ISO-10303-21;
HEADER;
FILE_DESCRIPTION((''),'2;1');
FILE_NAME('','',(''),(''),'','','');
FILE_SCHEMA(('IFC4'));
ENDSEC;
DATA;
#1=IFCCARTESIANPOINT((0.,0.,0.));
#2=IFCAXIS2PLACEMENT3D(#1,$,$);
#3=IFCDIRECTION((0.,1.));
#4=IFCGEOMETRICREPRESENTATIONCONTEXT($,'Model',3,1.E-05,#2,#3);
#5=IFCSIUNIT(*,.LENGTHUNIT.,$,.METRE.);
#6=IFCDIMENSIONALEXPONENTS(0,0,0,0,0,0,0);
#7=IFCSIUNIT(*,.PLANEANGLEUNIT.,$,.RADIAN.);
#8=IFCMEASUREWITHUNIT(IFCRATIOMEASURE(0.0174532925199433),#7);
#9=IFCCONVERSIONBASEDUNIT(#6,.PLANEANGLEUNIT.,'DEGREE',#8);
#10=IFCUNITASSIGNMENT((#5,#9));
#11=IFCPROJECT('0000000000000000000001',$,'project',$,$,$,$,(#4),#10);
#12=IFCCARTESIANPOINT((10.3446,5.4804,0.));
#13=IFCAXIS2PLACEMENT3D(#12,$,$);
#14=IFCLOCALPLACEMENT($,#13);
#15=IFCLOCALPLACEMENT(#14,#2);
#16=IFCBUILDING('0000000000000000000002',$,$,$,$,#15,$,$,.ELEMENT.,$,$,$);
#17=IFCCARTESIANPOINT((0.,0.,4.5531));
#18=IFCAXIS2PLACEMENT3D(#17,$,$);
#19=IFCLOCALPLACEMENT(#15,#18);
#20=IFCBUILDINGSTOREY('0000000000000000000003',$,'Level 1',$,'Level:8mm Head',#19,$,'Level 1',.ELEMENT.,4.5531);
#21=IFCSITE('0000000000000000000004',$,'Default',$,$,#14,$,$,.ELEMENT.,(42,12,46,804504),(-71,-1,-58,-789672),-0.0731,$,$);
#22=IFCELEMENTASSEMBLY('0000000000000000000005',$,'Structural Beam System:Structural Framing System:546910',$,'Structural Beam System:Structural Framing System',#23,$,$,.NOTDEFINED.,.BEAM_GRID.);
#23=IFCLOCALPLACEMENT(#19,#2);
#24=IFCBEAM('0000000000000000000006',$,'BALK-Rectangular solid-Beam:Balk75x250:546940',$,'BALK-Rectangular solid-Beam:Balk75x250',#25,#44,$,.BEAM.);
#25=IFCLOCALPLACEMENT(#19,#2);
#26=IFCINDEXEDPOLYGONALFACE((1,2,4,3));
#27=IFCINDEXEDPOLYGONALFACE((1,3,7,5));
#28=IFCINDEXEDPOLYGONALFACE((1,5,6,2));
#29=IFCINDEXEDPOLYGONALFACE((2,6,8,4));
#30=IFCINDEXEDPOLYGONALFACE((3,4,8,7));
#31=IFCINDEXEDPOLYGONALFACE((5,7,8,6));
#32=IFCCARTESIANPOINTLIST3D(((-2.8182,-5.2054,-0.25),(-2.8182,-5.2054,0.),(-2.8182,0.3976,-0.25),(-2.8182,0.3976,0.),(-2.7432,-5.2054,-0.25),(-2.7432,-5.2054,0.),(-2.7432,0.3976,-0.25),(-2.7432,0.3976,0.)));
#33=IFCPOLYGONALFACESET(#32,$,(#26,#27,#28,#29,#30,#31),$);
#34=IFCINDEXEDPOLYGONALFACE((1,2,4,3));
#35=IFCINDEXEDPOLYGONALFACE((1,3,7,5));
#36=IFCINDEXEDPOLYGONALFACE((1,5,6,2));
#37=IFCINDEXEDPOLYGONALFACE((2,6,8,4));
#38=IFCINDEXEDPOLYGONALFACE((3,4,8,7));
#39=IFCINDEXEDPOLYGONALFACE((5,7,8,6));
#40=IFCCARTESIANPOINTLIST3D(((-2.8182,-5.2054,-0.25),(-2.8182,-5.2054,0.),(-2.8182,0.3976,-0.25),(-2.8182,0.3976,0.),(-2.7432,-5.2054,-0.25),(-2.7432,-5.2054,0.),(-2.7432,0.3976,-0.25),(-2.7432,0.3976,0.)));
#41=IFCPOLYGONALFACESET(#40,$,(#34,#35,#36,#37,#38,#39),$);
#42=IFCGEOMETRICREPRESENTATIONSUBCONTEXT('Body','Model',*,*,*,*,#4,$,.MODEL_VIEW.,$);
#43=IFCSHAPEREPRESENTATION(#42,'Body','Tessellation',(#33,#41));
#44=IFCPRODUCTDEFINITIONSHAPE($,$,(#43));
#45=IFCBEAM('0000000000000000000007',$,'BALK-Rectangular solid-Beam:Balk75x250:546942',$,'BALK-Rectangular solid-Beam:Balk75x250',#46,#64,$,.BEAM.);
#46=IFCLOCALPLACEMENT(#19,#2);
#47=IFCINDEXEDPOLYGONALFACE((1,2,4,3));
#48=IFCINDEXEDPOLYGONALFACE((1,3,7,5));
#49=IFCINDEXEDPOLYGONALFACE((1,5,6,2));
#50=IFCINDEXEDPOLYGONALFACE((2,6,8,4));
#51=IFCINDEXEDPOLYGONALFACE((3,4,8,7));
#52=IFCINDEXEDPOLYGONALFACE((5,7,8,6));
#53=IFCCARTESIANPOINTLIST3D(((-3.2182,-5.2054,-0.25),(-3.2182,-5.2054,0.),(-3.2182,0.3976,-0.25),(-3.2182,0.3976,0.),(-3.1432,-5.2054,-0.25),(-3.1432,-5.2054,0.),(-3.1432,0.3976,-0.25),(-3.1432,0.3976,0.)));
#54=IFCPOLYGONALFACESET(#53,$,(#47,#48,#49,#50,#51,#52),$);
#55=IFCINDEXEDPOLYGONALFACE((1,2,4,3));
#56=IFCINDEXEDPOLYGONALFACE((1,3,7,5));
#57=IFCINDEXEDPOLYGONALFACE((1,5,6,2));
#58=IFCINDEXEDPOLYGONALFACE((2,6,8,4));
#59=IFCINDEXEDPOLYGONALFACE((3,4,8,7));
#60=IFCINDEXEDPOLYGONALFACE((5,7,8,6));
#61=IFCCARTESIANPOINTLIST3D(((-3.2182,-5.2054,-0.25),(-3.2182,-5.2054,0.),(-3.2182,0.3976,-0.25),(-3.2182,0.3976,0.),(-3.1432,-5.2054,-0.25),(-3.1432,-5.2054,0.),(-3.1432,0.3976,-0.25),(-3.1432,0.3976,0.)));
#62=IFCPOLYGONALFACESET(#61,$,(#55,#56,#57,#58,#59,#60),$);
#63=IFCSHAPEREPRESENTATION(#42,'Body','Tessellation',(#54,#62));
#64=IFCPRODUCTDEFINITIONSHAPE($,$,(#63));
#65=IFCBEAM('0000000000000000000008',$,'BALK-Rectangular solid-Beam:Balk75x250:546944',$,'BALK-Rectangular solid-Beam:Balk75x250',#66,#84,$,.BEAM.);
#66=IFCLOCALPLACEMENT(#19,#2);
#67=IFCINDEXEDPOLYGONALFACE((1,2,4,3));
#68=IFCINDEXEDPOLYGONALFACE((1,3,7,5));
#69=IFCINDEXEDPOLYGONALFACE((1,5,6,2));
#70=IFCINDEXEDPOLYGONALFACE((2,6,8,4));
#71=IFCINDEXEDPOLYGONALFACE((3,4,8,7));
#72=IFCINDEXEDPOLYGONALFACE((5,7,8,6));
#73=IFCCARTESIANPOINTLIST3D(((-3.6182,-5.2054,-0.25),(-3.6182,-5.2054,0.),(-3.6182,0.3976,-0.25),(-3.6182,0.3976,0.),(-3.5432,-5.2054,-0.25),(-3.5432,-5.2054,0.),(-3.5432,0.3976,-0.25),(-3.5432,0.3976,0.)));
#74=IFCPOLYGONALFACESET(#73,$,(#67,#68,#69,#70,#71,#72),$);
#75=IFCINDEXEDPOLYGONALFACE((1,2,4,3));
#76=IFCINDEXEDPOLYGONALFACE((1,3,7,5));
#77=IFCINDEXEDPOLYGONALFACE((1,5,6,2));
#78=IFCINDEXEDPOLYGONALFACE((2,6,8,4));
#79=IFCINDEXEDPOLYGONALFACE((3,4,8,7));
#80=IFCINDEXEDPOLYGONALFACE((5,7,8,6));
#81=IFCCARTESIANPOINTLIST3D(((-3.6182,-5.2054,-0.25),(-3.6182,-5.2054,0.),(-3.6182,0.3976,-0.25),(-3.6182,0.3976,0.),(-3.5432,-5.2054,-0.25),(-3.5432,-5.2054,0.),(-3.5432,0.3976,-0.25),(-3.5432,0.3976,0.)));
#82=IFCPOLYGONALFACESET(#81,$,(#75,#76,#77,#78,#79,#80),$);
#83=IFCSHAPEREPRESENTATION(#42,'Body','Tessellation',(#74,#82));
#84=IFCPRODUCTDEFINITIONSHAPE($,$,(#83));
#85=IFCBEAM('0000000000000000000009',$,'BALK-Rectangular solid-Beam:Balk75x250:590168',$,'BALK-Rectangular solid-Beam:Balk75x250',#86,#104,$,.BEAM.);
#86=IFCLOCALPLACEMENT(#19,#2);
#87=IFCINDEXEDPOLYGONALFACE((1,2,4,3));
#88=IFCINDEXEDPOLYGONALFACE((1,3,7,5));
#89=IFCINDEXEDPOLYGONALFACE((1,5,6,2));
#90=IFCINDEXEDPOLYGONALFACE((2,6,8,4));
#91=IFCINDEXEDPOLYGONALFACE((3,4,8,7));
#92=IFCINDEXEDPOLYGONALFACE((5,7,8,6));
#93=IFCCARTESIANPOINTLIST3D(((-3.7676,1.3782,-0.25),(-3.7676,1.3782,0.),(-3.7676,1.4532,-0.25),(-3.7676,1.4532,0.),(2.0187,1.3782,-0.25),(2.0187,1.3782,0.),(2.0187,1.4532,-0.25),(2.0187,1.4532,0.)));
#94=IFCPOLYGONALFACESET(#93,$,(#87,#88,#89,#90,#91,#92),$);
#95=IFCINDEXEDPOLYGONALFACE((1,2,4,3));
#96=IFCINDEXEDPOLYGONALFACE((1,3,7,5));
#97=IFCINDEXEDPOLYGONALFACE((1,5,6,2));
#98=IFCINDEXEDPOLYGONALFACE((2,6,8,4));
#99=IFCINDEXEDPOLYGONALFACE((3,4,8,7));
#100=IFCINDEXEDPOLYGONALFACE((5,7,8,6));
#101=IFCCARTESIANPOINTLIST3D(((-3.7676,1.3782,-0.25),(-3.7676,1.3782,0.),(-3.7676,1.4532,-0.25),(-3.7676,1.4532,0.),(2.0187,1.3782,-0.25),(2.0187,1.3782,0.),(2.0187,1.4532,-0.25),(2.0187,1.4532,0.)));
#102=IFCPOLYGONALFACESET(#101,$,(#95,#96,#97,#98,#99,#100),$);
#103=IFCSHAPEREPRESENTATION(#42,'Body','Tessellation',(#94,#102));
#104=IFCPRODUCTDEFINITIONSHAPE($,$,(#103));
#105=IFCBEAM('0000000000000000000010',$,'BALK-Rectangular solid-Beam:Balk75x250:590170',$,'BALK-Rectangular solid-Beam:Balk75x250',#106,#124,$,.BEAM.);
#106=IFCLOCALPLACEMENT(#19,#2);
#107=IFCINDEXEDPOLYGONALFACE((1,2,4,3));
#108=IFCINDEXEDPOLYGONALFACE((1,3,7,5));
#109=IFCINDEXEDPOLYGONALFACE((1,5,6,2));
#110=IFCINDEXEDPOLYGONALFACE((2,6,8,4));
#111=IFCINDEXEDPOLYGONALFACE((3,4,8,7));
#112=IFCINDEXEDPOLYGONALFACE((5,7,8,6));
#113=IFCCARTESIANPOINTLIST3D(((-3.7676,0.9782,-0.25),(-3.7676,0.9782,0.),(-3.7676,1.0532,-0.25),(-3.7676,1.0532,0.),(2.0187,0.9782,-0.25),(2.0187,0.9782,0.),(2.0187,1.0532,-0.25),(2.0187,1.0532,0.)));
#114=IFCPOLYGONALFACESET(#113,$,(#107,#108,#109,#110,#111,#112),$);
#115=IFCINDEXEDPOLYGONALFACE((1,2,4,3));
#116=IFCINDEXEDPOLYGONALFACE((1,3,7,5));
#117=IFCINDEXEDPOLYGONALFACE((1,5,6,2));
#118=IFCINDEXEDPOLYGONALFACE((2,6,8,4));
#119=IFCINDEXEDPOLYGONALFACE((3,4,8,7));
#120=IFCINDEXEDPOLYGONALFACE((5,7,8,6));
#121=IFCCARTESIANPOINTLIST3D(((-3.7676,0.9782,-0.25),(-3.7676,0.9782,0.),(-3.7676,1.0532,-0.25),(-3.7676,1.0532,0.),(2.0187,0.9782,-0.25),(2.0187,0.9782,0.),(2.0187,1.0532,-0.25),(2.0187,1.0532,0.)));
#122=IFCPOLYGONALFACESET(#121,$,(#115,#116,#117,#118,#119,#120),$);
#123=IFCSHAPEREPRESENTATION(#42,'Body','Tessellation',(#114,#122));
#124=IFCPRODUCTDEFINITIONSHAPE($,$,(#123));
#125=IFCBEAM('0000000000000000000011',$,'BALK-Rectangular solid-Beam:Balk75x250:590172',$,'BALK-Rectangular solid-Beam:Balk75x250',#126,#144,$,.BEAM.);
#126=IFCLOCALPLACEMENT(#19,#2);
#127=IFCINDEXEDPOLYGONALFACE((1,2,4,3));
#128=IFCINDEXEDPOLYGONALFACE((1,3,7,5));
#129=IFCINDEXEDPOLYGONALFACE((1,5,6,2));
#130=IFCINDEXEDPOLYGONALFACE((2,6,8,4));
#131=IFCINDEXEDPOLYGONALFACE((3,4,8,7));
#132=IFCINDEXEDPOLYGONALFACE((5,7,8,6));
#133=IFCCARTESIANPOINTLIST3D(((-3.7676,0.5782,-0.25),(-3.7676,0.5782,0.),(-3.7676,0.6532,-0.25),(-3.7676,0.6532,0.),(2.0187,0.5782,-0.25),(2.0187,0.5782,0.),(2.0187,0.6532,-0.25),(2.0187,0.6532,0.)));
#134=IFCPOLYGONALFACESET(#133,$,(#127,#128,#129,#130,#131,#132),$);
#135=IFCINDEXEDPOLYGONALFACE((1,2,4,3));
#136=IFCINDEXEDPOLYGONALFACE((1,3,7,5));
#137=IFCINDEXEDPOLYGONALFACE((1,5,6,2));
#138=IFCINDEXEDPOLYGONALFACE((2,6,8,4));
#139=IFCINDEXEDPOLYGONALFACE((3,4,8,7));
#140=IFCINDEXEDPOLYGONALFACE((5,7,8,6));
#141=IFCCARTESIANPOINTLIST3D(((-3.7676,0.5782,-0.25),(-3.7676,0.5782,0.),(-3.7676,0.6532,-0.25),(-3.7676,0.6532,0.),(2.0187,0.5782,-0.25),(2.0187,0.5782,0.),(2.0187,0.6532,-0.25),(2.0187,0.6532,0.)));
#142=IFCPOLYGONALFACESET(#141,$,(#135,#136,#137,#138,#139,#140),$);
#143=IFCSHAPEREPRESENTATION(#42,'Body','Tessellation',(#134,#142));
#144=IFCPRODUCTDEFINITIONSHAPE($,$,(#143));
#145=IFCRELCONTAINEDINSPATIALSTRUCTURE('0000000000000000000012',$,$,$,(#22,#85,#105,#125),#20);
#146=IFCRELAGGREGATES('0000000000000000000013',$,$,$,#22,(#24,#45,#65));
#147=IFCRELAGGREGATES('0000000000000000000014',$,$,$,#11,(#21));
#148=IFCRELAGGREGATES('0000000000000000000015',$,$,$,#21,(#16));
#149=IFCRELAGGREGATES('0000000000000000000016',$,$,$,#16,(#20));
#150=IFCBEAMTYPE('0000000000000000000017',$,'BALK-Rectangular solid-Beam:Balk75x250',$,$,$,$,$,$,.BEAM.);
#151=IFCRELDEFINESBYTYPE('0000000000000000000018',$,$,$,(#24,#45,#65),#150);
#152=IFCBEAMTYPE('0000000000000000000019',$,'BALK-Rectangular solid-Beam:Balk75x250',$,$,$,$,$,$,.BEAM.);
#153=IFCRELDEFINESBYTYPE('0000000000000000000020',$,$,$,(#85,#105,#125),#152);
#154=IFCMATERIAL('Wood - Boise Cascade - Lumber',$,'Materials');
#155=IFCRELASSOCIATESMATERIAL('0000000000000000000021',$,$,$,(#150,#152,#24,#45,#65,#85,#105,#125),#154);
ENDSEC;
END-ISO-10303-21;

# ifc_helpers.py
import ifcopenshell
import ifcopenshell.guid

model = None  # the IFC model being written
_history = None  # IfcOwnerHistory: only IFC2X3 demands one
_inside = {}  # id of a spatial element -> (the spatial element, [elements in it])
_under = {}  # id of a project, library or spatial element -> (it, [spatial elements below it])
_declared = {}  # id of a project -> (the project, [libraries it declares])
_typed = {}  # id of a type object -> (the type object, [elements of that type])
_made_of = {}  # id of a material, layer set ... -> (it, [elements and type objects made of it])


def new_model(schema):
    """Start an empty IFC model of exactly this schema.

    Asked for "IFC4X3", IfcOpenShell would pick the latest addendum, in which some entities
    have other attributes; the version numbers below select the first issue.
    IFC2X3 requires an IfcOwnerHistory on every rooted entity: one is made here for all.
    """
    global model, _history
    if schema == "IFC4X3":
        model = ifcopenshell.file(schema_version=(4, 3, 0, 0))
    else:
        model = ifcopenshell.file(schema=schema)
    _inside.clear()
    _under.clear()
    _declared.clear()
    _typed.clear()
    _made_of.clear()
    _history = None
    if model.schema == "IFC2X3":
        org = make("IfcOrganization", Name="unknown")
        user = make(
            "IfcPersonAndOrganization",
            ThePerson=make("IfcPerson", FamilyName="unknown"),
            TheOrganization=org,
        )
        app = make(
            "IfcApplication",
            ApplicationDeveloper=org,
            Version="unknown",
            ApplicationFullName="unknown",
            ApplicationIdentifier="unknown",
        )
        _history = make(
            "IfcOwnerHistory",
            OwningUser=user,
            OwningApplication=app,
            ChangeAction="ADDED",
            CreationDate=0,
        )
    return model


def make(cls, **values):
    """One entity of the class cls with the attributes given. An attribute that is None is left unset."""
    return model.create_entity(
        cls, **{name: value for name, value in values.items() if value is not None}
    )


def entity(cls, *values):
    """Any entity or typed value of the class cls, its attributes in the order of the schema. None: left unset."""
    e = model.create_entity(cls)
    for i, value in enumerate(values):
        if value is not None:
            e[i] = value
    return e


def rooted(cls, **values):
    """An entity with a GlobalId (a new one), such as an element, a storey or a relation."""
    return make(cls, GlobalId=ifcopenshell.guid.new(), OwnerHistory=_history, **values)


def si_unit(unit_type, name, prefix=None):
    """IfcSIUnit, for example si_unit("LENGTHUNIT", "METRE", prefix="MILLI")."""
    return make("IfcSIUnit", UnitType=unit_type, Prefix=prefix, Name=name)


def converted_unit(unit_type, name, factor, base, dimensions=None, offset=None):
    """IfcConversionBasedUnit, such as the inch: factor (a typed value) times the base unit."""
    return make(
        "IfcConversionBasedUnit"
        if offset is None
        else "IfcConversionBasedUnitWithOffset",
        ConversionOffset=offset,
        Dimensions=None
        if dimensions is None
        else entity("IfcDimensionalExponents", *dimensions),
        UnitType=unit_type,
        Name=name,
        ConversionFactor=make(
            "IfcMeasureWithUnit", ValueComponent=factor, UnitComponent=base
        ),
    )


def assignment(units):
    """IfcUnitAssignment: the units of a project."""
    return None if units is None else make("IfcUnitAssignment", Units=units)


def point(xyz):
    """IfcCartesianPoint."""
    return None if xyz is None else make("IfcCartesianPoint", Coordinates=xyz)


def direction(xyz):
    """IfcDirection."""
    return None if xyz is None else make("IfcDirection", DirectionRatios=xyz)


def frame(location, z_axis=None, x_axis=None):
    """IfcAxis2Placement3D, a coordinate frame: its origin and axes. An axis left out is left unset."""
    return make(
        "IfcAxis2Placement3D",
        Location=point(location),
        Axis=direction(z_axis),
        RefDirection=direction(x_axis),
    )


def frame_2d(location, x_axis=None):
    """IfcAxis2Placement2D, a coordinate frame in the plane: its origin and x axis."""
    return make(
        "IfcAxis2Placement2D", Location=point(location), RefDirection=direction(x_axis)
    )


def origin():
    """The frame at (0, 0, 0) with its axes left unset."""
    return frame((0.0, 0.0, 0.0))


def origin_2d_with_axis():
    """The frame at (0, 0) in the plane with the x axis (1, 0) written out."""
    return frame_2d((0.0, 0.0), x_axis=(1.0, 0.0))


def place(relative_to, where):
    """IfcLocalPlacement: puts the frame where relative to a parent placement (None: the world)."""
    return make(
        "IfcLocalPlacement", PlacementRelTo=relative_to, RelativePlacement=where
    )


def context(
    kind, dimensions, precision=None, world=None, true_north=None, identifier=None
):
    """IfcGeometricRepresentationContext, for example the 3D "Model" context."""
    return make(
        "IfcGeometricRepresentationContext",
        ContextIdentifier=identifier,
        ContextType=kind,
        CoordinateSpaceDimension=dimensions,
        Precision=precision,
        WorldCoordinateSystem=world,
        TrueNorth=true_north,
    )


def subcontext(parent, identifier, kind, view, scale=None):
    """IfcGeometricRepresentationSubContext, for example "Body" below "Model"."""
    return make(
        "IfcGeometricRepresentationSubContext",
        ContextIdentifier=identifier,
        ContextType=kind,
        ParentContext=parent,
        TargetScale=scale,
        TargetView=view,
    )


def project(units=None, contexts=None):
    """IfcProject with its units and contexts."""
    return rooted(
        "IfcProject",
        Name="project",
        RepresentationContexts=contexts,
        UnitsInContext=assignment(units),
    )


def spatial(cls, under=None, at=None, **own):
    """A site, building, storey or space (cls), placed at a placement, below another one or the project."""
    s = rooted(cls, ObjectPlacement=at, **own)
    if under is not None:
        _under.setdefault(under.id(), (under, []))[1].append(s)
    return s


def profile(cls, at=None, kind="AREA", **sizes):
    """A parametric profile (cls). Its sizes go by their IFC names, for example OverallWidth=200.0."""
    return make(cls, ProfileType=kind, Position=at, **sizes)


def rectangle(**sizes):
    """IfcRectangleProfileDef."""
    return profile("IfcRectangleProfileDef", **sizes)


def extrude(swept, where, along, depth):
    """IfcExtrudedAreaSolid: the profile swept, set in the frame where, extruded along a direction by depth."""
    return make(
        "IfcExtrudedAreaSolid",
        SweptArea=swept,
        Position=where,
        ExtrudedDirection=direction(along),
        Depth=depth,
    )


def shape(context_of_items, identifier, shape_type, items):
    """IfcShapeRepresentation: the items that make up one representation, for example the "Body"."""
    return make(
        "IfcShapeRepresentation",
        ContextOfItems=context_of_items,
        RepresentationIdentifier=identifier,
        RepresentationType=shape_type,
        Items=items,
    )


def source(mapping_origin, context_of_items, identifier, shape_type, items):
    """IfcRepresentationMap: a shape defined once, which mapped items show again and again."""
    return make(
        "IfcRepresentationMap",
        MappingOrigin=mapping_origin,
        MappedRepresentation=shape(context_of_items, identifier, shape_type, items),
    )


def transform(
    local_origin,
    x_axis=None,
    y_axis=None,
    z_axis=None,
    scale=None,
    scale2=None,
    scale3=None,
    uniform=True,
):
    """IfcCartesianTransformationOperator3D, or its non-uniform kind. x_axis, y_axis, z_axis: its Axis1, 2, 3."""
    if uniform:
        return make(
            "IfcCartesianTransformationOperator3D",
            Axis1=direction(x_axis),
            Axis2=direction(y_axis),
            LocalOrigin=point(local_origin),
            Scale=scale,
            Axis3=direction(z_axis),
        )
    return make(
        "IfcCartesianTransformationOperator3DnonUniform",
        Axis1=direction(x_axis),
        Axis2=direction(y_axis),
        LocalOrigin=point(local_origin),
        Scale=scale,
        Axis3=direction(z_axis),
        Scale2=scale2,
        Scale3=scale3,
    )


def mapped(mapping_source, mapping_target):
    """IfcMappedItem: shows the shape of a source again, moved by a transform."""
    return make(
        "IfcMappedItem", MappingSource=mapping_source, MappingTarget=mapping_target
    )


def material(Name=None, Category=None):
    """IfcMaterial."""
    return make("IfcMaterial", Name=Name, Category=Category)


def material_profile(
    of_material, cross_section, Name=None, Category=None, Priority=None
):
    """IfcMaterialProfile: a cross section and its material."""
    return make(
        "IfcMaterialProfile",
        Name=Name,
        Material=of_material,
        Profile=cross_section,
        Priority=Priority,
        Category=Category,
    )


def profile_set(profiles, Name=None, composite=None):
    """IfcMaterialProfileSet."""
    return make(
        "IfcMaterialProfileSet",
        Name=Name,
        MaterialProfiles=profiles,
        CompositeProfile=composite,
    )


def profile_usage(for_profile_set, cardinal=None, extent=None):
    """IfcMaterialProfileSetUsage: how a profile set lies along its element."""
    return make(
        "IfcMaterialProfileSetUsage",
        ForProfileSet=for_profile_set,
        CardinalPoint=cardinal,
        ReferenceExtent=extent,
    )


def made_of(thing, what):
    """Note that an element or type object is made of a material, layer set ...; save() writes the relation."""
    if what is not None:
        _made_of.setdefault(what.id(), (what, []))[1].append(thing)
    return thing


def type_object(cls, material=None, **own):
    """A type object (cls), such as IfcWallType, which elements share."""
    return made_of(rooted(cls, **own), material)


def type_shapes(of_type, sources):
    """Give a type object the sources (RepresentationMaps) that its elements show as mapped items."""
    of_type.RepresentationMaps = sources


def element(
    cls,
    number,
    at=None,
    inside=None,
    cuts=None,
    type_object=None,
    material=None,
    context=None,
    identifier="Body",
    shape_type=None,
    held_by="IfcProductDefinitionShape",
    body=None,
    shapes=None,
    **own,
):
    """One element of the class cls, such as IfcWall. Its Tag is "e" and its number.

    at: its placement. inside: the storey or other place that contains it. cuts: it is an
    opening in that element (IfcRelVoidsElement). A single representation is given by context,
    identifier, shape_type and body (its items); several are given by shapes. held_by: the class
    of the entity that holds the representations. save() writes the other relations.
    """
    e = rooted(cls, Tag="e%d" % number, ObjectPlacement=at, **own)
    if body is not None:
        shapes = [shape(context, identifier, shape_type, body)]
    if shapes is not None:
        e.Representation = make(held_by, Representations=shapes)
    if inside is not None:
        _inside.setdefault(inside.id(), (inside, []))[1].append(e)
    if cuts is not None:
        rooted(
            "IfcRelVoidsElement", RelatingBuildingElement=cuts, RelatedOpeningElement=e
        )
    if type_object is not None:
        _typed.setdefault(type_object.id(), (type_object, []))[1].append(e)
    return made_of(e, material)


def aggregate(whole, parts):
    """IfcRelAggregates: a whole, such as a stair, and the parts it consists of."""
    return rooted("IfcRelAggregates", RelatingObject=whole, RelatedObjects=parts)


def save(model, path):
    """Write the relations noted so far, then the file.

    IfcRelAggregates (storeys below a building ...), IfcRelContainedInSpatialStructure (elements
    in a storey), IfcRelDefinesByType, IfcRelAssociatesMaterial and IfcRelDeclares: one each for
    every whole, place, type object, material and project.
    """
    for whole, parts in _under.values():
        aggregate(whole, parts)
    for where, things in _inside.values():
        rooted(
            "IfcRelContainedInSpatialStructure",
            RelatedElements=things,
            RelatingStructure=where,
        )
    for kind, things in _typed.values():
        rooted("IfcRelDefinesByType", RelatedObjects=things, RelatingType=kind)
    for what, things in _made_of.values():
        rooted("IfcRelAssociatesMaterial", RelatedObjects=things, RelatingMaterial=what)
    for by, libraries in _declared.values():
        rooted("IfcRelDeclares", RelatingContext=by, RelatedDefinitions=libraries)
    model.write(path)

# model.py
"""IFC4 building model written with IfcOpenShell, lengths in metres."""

from ifc_helpers import new_model, entity, si_unit, converted_unit, direction, frame, frame_2d, origin, origin_2d_with_axis, place, context, subcontext, project, spatial, rectangle, extrude, source, transform, mapped, material, material_profile, profile_set, profile_usage, type_object, type_shapes, element, aggregate, save


model = new_model("IFC4")

# Units and contexts
model_context = context("Model", 3, precision=1e-05, world=origin(), true_north=direction((0.0, 1.0)))
body_context = subcontext(model_context, "Body", "Model", "MODEL_VIEW")
ifc_project = project(units=[si_unit("LENGTHUNIT", "METRE"), converted_unit("PLANEANGLEUNIT", "DEGREE", entity("IfcRatioMeasure", 0.0174532925199433), si_unit("PLANEANGLEUNIT", "RADIAN"), dimensions=[0, 0, 0, 0, 0, 0, 0])], contexts=[model_context])

# Site, building, storey
site_placement = place(None, frame((10.3446, 5.4804, 0.0)))
site = spatial("IfcSite", under=ifc_project, at=site_placement, Name="Default", CompositionType="ELEMENT", RefLatitude=(42, 12, 46, 804504), RefLongitude=(-71, -1, -58, -789672), RefElevation=-0.0731)
building_placement = place(site_placement, origin())
building = spatial("IfcBuilding", under=site, at=building_placement, CompositionType="ELEMENT")
storey_placement = place(building_placement, frame((0.0, 0.0, 4.5531)))
storey = spatial("IfcBuildingStorey", under=building, at=storey_placement, Name="Level 1", ObjectType="Level:8mm Head", LongName="Level 1", CompositionType="ELEMENT", Elevation=4.5531)

# Element assembly, beams
ifc_material = material(Name="Wood - Boise Cascade - Lumber", Category="Materials")
ifc_material_profile = material_profile(ifc_material, rectangle(XDim=0.25, YDim=0.075, at=frame_2d((0.0, 0.0), x_axis=(1.0, 0.0))), Name="Balk75x250")
ifc_profile_set = profile_set([ifc_material_profile], Name="Balk75x250")
assembly_1_placement = place(storey_placement, origin())
assembly_1 = element("IfcElementAssembly", 1, at=assembly_1_placement, inside=storey, Name="Structural Beam System:Structural Framing System:546910", ObjectType="Structural Beam System:Structural Framing System", AssemblyPlace="NOTDEFINED", PredefinedType="BEAM_GRID")
beam_type_1 = type_object("IfcBeamType", Name="BALK-Rectangular solid-Beam:Balk75x250", PredefinedType="BEAM", material=ifc_profile_set)
shared_shape_1 = source(origin(), body_context, "Body", "SweptSolid", [
    extrude(rectangle(XDim=0.25, YDim=0.075, at=origin_2d_with_axis()), frame((-2.9078, 0.0, 0.0), z_axis=(1.0, 0.0, 0.0), x_axis=(0.0, 0.0, -1.0)), (0.0, 0.0, 1.0), 5.603),
    extrude(rectangle(XDim=0.25, YDim=0.075, at=origin_2d_with_axis()), frame((-2.9078, 0.0, 0.0), z_axis=(1.0, 0.0, 0.0), x_axis=(0.0, 0.0, -1.0)), (0.0, 0.0, 1.0), 5.603),
])
type_shapes(beam_type_1, [shared_shape_1])
ifc_profile_usage_1 = profile_usage(ifc_profile_set, cardinal=8)
beam_1_placement = place(assembly_1_placement, frame((-2.7807, -2.5102, -0.125), z_axis=(0.0, 0.0, 1.0), x_axis=(0.0, -1.0, 0.0)))
beam_1 = element("IfcBeam", 2, at=beam_1_placement, type_object=beam_type_1, material=ifc_profile_usage_1, Name="BALK-Rectangular solid-Beam:Balk75x250:546940", ObjectType="BALK-Rectangular solid-Beam:Balk75x250", PredefinedType="BEAM", context=body_context, shape_type="MappedRepresentation", body=[
    mapped(shared_shape_1, transform((0.0, 0.0, 0.0), scale=1.0)),
])
ifc_profile_usage_2 = profile_usage(ifc_profile_set, cardinal=8)
beam_2_placement = place(assembly_1_placement, frame((-3.1807, -2.5102, -0.125), z_axis=(0.0, 0.0, 1.0), x_axis=(0.0, -1.0, 0.0)))
beam_2 = element("IfcBeam", 3, at=beam_2_placement, type_object=beam_type_1, material=ifc_profile_usage_2, Name="BALK-Rectangular solid-Beam:Balk75x250:546942", ObjectType="BALK-Rectangular solid-Beam:Balk75x250", PredefinedType="BEAM", context=body_context, shape_type="MappedRepresentation", body=[
    mapped(shared_shape_1, transform((0.0, 0.0, 0.0), scale=1.0)),
])
ifc_profile_usage_3 = profile_usage(ifc_profile_set, cardinal=8)
beam_3_placement = place(assembly_1_placement, frame((-3.5807, -2.5102, -0.125), z_axis=(0.0, 0.0, 1.0), x_axis=(0.0, -1.0, 0.0)))
beam_3 = element("IfcBeam", 4, at=beam_3_placement, type_object=beam_type_1, material=ifc_profile_usage_3, Name="BALK-Rectangular solid-Beam:Balk75x250:546944", ObjectType="BALK-Rectangular solid-Beam:Balk75x250", PredefinedType="BEAM", context=body_context, shape_type="MappedRepresentation", body=[
    mapped(shared_shape_1, transform((0.0, 0.0, 0.0), scale=1.0)),
])
aggregate(assembly_1, [beam_1, beam_2, beam_3])

# Beams
ifc_profile_usage_4 = profile_usage(ifc_profile_set, cardinal=8)
beam_type_2 = type_object("IfcBeamType", Name="BALK-Rectangular solid-Beam:Balk75x250", PredefinedType="BEAM", material=ifc_profile_set)
shared_shape_2 = source(origin(), body_context, "Body", "SweptSolid", [
    extrude(rectangle(XDim=0.25, YDim=0.075, at=origin_2d_with_axis()), frame((-2.9869, 0.0, 0.0), z_axis=(1.0, 0.0, 0.0), x_axis=(0.0, 0.0, -1.0)), (0.0, 0.0, 1.0), 5.7863),
    extrude(rectangle(XDim=0.25, YDim=0.075, at=origin_2d_with_axis()), frame((-2.9869, 0.0, 0.0), z_axis=(1.0, 0.0, 0.0), x_axis=(0.0, 0.0, -1.0)), (0.0, 0.0, 1.0), 5.7863),
])
type_shapes(beam_type_2, [shared_shape_2])
beam_4_placement = place(storey_placement, frame((-0.7807, 1.4157, -0.125)))
element("IfcBeam", 5, at=beam_4_placement, inside=storey, type_object=beam_type_2, material=ifc_profile_usage_4, Name="BALK-Rectangular solid-Beam:Balk75x250:590168", ObjectType="BALK-Rectangular solid-Beam:Balk75x250", PredefinedType="BEAM", context=body_context, shape_type="MappedRepresentation", body=[
    mapped(shared_shape_2, transform((0.0, 0.0, 0.0), scale=1.0)),
])
ifc_profile_usage_5 = profile_usage(ifc_profile_set, cardinal=8)
beam_5_placement = place(storey_placement, frame((-0.7807, 1.0157, -0.125)))
element("IfcBeam", 6, at=beam_5_placement, inside=storey, type_object=beam_type_2, material=ifc_profile_usage_5, Name="BALK-Rectangular solid-Beam:Balk75x250:590170", ObjectType="BALK-Rectangular solid-Beam:Balk75x250", PredefinedType="BEAM", context=body_context, shape_type="MappedRepresentation", body=[
    mapped(shared_shape_2, transform((0.0, 0.0, 0.0), scale=1.0)),
])
ifc_profile_usage_6 = profile_usage(ifc_profile_set, cardinal=8)
beam_6_placement = place(storey_placement, frame((-0.7807, 0.6157, -0.125)))
element("IfcBeam", 7, at=beam_6_placement, inside=storey, type_object=beam_type_2, material=ifc_profile_usage_6, Name="BALK-Rectangular solid-Beam:Balk75x250:590172", ObjectType="BALK-Rectangular solid-Beam:Balk75x250", PredefinedType="BEAM", context=body_context, shape_type="MappedRepresentation", body=[
    mapped(shared_shape_2, transform((0.0, 0.0, 0.0), scale=1.0)),
])

save(model, "model.ifc")
